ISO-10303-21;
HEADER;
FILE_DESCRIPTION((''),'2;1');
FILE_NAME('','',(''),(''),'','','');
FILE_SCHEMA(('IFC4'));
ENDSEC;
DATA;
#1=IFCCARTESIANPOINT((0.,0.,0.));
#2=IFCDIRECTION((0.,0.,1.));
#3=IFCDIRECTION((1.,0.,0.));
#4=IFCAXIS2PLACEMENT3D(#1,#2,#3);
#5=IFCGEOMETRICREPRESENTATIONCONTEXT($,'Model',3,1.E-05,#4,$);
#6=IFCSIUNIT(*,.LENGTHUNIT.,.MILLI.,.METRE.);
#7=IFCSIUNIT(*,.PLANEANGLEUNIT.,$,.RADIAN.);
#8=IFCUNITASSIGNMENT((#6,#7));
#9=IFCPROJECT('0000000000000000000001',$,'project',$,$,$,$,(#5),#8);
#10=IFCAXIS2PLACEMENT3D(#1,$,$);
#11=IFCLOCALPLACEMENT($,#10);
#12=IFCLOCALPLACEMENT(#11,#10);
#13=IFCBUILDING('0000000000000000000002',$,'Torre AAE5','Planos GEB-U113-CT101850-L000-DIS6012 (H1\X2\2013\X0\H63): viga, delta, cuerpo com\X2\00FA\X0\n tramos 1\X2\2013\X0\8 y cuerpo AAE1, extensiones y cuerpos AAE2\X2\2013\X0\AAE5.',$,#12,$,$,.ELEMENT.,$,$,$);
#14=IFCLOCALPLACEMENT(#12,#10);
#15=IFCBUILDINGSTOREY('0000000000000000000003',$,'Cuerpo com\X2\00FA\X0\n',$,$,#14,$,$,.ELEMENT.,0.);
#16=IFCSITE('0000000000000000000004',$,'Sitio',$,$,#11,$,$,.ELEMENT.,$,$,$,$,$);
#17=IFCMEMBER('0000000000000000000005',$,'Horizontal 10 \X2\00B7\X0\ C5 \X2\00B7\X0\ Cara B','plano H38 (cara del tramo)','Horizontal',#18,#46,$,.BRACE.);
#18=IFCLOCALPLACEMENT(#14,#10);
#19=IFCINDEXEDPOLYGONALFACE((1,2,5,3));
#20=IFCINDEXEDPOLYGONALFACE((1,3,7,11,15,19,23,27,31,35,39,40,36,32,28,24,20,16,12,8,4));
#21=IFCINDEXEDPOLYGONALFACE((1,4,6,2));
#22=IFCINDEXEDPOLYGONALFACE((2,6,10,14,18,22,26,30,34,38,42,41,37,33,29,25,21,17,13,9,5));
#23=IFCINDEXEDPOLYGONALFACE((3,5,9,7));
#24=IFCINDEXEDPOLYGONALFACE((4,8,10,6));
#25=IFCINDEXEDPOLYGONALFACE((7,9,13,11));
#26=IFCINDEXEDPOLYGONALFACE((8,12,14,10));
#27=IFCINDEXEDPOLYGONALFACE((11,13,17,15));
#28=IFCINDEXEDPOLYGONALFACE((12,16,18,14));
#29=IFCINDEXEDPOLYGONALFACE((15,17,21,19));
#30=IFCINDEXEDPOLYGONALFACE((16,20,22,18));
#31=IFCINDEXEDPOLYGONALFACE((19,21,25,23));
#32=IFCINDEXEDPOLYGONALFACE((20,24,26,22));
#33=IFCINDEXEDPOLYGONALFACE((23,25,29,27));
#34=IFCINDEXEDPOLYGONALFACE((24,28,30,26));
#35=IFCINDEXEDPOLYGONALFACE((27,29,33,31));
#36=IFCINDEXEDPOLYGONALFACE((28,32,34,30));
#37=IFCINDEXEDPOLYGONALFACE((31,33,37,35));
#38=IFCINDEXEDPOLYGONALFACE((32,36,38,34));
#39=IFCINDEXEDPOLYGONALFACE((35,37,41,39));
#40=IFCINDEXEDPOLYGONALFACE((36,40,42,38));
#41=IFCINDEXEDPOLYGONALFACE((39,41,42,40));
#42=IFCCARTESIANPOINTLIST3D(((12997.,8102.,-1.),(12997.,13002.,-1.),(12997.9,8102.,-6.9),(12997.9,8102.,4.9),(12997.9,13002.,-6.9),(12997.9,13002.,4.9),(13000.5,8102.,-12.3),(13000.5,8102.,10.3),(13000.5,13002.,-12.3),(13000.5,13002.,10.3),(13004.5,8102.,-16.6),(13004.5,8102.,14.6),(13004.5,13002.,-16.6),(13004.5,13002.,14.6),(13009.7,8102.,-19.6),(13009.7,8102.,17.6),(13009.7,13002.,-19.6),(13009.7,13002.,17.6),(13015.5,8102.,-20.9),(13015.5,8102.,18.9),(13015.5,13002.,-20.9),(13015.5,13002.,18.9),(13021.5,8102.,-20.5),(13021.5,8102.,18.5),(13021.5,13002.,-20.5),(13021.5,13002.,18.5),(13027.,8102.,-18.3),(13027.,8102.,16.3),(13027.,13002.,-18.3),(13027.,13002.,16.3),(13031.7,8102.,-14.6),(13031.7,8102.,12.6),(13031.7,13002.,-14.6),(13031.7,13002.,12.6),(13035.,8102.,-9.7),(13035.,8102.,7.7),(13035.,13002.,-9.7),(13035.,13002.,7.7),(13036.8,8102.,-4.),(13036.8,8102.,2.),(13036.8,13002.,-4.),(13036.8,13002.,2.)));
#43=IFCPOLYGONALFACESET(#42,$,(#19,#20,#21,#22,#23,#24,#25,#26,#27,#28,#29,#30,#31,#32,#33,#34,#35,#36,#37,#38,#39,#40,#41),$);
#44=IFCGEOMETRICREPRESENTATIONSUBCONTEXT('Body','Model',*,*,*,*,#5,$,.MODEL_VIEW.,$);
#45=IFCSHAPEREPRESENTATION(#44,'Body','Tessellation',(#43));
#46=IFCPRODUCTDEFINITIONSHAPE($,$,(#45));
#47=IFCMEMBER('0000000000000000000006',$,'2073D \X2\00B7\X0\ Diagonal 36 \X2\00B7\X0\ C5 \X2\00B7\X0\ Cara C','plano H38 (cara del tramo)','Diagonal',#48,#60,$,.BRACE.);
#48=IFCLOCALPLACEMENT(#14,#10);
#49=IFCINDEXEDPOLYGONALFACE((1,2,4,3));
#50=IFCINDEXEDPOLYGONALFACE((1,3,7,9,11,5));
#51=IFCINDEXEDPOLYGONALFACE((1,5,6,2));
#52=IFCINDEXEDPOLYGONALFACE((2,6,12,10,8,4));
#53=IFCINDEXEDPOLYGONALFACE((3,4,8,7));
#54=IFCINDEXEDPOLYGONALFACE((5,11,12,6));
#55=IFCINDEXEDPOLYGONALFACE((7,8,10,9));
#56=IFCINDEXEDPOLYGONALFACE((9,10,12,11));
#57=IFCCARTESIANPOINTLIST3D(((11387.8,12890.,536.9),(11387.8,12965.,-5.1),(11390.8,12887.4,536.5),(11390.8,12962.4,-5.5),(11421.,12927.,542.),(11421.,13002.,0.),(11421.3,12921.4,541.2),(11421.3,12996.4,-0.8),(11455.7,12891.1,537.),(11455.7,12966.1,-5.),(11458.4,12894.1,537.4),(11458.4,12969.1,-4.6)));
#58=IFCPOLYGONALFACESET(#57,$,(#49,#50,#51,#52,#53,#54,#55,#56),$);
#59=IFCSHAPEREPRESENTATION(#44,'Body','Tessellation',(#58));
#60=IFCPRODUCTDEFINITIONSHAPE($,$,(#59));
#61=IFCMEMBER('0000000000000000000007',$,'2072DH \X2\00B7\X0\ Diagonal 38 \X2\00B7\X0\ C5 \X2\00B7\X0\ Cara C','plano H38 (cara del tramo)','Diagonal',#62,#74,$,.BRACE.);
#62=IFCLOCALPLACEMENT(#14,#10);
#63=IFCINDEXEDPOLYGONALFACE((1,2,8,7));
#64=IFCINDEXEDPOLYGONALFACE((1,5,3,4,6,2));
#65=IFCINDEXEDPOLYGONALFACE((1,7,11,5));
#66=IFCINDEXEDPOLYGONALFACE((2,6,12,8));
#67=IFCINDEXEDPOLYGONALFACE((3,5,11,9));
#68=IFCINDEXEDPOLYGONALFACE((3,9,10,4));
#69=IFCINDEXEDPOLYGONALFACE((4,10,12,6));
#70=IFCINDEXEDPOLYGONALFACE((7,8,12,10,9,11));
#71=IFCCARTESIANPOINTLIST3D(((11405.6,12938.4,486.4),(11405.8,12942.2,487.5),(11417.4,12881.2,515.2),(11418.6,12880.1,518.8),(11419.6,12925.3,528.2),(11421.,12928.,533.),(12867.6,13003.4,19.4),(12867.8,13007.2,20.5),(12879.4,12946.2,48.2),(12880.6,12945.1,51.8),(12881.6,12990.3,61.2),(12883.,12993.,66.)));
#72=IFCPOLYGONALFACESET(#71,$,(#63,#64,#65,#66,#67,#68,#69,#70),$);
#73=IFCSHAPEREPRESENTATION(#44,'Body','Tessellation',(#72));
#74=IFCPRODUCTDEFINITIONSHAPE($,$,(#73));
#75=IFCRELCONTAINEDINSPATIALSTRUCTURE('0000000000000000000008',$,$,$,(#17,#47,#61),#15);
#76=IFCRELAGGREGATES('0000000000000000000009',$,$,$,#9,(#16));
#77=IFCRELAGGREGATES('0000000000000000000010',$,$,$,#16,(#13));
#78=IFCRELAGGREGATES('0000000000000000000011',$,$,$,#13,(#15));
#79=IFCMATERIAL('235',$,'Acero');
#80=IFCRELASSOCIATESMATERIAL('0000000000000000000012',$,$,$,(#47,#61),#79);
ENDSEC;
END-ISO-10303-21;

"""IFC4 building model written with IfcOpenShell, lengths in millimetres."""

from ifc_helpers import new_model, si_unit, frame, frame_2d, origin, origin_with_axes, place, context, subcontext, project, spatial, circle, l_section, extrude, material, element, save


model = new_model("IFC4")

# Units and contexts
model_context = context("Model", 3, precision=1e-05, world=origin_with_axes())
body_context = subcontext(model_context, "Body", "Model", "MODEL_VIEW")
ifc_project = project(units=[si_unit("LENGTHUNIT", "METRE", prefix="MILLI"), si_unit("PLANEANGLEUNIT", "RADIAN")], contexts=[model_context])

# Site, building, storey
site_placement = place(None, origin())
site = spatial("IfcSite", under=ifc_project, at=site_placement, Name="Sitio", CompositionType="ELEMENT")
building_placement = place(site_placement, origin())
building = spatial("IfcBuilding", under=site, at=building_placement, Name="Torre AAE5", Description="Planos GEB-U113-CT101850-L000-DIS6012 (H1–H63): viga, delta, cuerpo común tramos 1–8 y cuerpo AAE1, extensiones y cuerpos AAE2–AAE5.", CompositionType="ELEMENT")
storey_placement = place(building_placement, origin())
storey = spatial("IfcBuildingStorey", under=building, at=storey_placement, Name="Cuerpo común", CompositionType="ELEMENT", Elevation=0.0)

# Members
ifc_material_1 = material(Name="235", Category="Acero")
for number, where, z_axis, x_axis, name in (
    (1, (13017.0, 13002.0, -1.0), (0.0, -1.0, 0.0), (-1.0, 0.0, 0.0), "Horizontal 10 · C5 · Cara B"),
):
    element("IfcMember", number, at=place(storey_placement, frame(where, z_axis=z_axis, x_axis=x_axis)), inside=storey, Name=name, Description="plano H38 (cara del tramo)", ObjectType="Horizontal", PredefinedType="BRACE", context=body_context, shape_type="SweptSolid", body=[
        extrude(circle(Radius=20.0), None, (0.0, 0.0, 1.0), 4900.0),
    ])
member_1_placement = place(storey_placement, frame((11421.0, 13002.0, 0.0), z_axis=(0.0, -0.13707, 0.990561), x_axis=(-0.664551, -0.74019, -0.102425)))
element("IfcMember", 2, at=member_1_placement, inside=storey, material=ifc_material_1, Name="2073D · Diagonal 36 · C5 · Cara C", Description="plano H38 (cara del tramo)", ObjectType="Diagonal", PredefinedType="BRACE", context=body_context, shape_type="SweptSolid", body=[
    extrude(l_section(Depth=50.0, Width=50.0, Thickness=4.0, at=frame_2d((25.0, 25.0))), None, (0.0, 0.0, 1.0), 547.2),
])
member_2_placement = place(storey_placement, frame((11421.0, 12928.0, 533.0), z_axis=(0.95173, 0.042314, -0.304007), x_axis=(-0.04793, -0.957813, -0.283366)))
element("IfcMember", 3, at=member_2_placement, inside=storey, material=ifc_material_1, Name="2072DH · Diagonal 38 · C5 · Cara C", Description="plano H38 (cara del tramo)", ObjectType="Diagonal", PredefinedType="BRACE", context=body_context, shape_type="SweptSolid", body=[
    extrude(l_section(Depth=50.0, Width=50.0, Thickness=4.0, at=frame_2d((25.0, 25.0))), None, (0.0, 0.0, 1.0), 1536.2),
])

save(model, "model.ifc")
